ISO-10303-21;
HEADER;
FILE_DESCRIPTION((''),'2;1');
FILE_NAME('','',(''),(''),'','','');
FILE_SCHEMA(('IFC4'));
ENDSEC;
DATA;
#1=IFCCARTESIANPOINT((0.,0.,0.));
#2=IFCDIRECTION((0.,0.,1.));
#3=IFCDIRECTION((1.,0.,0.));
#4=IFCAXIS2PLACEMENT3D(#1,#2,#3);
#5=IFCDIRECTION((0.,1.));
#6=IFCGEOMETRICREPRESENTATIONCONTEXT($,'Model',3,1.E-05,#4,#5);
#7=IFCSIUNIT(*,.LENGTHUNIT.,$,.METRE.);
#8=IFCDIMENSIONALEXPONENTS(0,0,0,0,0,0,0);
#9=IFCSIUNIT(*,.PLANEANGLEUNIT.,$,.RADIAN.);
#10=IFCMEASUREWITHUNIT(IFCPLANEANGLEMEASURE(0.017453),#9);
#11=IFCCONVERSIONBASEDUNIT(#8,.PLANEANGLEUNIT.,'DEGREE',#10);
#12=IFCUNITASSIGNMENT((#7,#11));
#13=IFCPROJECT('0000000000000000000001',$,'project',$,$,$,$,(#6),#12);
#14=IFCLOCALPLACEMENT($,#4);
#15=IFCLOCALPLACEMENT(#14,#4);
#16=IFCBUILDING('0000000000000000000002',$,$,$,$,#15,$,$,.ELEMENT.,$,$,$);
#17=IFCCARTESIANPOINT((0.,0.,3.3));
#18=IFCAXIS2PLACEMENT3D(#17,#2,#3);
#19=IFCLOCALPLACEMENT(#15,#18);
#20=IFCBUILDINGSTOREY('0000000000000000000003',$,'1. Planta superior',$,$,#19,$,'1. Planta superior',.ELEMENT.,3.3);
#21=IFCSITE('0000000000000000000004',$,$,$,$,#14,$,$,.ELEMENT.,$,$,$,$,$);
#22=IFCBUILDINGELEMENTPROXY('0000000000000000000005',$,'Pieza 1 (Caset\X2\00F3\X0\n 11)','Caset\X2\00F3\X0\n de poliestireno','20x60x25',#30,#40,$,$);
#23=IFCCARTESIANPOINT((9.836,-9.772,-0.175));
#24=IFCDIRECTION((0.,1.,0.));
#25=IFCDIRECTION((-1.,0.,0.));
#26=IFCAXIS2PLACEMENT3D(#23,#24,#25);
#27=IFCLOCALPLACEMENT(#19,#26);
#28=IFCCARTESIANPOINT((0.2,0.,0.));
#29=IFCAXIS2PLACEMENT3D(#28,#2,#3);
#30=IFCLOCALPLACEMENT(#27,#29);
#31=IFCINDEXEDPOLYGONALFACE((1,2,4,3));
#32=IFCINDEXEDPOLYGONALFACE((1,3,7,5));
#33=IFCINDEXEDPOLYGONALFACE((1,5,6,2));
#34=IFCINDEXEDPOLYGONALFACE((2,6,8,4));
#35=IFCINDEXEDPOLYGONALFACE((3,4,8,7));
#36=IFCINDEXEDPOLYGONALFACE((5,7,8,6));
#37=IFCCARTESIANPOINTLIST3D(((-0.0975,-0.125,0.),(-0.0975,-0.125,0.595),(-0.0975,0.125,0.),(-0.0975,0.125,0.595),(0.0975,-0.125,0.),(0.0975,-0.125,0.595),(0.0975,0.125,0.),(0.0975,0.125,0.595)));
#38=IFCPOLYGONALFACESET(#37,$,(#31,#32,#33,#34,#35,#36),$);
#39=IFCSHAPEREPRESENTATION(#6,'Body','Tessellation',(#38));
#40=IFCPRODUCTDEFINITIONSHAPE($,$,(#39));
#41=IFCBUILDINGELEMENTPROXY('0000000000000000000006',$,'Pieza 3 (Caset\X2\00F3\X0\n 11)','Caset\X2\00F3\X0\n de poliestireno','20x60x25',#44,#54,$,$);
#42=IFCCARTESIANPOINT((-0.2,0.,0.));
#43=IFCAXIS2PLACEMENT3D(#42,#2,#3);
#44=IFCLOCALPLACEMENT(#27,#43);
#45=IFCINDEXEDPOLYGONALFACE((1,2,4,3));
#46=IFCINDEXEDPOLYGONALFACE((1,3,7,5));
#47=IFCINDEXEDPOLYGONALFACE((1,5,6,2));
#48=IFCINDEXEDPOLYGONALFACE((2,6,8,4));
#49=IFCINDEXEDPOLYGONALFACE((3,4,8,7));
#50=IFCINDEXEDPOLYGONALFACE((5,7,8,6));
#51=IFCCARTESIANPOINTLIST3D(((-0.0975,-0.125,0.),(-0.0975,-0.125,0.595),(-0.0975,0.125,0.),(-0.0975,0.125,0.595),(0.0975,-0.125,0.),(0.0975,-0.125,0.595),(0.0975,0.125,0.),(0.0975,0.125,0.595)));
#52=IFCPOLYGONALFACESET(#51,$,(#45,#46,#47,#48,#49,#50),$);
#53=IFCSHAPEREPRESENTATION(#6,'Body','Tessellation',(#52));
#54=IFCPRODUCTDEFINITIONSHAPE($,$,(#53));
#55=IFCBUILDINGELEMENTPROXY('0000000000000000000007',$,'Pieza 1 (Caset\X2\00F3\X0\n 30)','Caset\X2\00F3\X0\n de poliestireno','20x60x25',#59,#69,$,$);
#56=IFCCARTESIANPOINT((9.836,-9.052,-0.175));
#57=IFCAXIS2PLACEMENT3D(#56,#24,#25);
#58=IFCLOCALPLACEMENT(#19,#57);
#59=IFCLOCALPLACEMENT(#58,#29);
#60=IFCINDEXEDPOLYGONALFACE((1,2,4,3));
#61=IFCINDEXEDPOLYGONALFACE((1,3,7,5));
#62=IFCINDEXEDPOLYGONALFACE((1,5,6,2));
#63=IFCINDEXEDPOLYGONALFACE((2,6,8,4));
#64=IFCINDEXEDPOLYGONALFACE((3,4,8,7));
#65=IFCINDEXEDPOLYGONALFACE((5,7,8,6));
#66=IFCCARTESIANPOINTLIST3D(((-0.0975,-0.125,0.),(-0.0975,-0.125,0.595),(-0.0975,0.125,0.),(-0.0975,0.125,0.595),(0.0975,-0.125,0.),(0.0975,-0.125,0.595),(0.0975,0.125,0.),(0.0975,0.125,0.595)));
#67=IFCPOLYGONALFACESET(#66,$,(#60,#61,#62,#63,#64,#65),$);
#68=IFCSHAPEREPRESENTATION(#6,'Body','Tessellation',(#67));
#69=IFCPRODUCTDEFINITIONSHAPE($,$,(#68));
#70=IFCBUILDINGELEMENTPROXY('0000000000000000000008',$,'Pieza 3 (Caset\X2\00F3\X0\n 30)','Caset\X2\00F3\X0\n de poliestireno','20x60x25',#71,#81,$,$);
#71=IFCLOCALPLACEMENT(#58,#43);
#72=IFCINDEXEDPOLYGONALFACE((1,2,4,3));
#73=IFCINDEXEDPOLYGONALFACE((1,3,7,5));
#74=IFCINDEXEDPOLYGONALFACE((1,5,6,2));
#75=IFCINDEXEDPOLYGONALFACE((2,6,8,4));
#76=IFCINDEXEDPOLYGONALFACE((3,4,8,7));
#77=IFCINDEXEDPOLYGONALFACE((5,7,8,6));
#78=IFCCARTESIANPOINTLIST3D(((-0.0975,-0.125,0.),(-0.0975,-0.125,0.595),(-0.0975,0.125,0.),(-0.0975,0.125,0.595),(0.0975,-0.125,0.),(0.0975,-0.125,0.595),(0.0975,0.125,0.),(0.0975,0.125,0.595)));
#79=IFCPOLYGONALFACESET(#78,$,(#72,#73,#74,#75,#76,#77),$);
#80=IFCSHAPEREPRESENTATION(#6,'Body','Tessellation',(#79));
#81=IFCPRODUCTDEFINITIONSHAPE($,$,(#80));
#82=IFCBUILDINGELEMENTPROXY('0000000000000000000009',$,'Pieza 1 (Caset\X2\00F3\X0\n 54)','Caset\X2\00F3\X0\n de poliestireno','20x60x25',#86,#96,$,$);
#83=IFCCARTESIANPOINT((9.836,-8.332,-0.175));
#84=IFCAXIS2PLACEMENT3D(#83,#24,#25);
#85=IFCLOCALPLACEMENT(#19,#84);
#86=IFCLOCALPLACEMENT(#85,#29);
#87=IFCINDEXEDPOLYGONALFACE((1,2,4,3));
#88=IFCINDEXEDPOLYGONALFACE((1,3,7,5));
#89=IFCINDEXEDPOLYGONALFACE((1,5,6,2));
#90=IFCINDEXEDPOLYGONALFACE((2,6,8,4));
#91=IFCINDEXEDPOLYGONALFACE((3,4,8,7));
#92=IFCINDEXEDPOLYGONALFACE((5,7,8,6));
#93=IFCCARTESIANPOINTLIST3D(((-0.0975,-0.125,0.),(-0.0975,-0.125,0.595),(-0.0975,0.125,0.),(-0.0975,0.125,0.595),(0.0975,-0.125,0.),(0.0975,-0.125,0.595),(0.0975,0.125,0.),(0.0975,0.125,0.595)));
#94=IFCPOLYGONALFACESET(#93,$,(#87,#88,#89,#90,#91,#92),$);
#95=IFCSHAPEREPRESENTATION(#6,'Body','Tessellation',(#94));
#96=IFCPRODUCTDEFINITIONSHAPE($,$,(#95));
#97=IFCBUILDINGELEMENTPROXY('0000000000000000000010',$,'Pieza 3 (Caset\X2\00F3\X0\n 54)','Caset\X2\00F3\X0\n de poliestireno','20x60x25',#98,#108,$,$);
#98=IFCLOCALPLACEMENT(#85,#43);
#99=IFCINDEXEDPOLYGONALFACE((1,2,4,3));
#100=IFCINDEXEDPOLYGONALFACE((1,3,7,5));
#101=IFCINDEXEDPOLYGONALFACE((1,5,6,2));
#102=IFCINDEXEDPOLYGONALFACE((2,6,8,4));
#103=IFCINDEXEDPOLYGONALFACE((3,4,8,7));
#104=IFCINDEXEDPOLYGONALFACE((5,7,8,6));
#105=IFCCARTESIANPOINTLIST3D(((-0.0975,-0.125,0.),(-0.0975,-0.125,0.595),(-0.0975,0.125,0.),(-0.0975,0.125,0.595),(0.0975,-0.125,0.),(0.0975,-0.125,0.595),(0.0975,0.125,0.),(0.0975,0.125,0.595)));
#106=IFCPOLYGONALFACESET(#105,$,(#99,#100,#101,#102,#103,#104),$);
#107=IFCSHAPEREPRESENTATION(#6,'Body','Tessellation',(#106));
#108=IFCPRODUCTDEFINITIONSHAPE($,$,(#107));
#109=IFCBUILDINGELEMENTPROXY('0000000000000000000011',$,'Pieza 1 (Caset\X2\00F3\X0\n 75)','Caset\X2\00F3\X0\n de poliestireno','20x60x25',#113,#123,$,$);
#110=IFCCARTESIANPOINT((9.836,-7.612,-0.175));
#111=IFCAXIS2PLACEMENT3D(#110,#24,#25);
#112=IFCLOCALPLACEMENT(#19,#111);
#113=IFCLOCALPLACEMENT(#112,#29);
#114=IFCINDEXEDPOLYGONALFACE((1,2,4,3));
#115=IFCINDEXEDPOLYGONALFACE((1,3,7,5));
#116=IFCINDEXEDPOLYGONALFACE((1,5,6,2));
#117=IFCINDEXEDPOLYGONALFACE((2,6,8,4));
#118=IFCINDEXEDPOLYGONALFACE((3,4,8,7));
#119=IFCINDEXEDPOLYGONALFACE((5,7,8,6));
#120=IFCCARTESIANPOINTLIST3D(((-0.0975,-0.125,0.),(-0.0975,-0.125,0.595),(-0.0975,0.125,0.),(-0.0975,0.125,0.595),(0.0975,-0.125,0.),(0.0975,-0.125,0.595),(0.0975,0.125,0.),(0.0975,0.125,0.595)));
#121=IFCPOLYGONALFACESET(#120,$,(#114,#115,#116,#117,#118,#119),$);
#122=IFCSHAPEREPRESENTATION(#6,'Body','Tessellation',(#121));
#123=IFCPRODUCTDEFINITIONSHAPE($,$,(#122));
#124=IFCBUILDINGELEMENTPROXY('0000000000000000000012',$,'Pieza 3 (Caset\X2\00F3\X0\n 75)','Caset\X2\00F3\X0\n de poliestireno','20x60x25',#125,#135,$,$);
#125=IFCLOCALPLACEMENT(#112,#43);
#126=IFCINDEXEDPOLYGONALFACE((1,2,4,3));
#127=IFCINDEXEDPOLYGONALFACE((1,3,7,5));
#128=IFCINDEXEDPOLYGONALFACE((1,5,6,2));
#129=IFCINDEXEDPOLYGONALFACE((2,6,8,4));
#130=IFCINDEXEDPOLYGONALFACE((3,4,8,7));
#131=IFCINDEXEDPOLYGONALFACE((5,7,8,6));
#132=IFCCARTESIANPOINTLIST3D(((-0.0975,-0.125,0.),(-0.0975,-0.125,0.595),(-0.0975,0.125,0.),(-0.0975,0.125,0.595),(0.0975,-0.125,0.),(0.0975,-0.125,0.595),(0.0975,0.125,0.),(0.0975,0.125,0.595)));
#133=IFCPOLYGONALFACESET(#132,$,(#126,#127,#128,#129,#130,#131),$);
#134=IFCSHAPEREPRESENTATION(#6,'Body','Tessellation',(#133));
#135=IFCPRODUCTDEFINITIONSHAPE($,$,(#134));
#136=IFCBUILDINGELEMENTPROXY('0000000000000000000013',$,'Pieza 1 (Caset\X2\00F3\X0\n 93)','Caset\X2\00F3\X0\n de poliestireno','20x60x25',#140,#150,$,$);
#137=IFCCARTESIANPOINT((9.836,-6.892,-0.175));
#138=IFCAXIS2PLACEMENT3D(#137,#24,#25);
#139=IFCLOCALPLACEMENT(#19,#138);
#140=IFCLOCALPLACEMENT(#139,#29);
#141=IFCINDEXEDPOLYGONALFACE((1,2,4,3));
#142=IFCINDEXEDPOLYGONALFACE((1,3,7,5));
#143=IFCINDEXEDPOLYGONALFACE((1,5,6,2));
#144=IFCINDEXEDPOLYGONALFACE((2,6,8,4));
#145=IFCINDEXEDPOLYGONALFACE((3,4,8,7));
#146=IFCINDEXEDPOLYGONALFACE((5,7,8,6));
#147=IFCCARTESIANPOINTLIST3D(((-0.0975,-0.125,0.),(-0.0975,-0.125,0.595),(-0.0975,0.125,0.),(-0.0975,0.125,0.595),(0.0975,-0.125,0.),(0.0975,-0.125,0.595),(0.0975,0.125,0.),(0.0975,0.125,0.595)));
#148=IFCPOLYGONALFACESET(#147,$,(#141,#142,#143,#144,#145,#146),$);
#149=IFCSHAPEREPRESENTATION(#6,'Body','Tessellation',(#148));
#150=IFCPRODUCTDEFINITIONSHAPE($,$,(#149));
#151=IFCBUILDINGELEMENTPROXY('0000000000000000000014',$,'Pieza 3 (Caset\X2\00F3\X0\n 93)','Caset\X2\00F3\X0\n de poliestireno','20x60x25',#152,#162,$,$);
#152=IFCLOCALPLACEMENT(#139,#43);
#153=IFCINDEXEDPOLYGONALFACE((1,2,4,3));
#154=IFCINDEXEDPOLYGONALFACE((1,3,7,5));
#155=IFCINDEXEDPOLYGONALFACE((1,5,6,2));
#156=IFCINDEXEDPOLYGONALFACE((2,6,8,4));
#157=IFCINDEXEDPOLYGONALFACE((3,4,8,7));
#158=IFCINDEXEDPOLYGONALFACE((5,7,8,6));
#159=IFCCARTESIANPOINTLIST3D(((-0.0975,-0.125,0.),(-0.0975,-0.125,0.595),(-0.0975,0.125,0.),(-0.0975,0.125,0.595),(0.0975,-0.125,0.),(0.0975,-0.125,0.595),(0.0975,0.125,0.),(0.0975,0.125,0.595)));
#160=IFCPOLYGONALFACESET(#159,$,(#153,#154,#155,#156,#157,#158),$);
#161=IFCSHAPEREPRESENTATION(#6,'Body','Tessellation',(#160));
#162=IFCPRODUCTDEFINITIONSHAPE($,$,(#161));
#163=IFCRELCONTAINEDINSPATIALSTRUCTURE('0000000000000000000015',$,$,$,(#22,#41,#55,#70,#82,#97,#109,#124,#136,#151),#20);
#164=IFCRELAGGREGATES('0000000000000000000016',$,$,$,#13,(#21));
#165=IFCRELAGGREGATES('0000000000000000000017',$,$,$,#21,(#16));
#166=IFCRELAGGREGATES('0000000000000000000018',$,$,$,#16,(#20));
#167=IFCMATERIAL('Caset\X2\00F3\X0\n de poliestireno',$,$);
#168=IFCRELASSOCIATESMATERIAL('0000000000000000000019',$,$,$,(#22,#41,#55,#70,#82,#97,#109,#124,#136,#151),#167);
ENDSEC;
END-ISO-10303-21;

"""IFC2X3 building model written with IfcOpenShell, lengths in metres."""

from ifc_helpers import new_model, entity, si_unit, converted_unit, direction, frame, origin_with_axes, origin_2d_with_axis, place, context, project, spatial, rectangle, extrude, source, transform, mapped, material, element, save


model = new_model("IFC2X3")

# Units and contexts
model_context = context("Model", 3, precision=1e-05, world=origin_with_axes(), true_north=direction((0.0, 1.0)))
ifc_project = project(units=[si_unit("LENGTHUNIT", "METRE"), converted_unit("PLANEANGLEUNIT", "DEGREE", entity("IfcPlaneAngleMeasure", 0.017453), si_unit("PLANEANGLEUNIT", "RADIAN"), dimensions=[0, 0, 0, 0, 0, 0, 0])], contexts=[model_context])

# Site, building, storey
site_placement = place(None, origin_with_axes())
site = spatial("IfcSite", under=ifc_project, at=site_placement, CompositionType="ELEMENT")
building_placement = place(site_placement, origin_with_axes())
building = spatial("IfcBuilding", under=site, at=building_placement, CompositionType="ELEMENT")
storey_placement = place(building_placement, frame((0.0, 0.0, 3.3), z_axis=(0.0, 0.0, 1.0), x_axis=(1.0, 0.0, 0.0)))
storey = spatial("IfcBuildingStorey", under=building, at=storey_placement, Name="1. Planta superior", LongName="1. Planta superior", CompositionType="ELEMENT", Elevation=3.3)

# Building element proxies
ifc_material = material(Name="Casetón de poliestireno")
shared_shape = source(origin_with_axes(), model_context, "Body", "SweptSolid", [
    extrude(rectangle(XDim=0.195, YDim=0.25, at=origin_2d_with_axis()), origin_with_axes(), (0.0, 0.0, 1.0), 0.595),
])
placement_1 = place(storey_placement, frame((9.836, -9.772, -0.175), z_axis=(0.0, 1.0, 0.0), x_axis=(-1.0, 0.0, 0.0)))
for number, where, z_axis, x_axis, name in (
    (1, (0.2, 0.0, 0.0), (0.0, 0.0, 1.0), (1.0, 0.0, 0.0), "Pieza 1 (Casetón 11)"),
    (2, (-0.2, 0.0, 0.0), (0.0, 0.0, 1.0), (1.0, 0.0, 0.0), "Pieza 3 (Casetón 11)"),
):
    element("IfcBuildingElementProxy", number, at=place(placement_1, frame(where, z_axis=z_axis, x_axis=x_axis)), inside=storey, material=ifc_material, Name=name, Description="Casetón de poliestireno", ObjectType="20x60x25", context=model_context, shape_type="MappedRepresentation", body=[
        mapped(shared_shape, transform((0.0, 0.0, 0.0), x_axis=(1.0, 0.0, 0.0), y_axis=(0.0, 1.0, 0.0), z_axis=(0.0, 0.0, 1.0))),
    ])
placement_2 = place(storey_placement, frame((9.836, -9.052, -0.175), z_axis=(0.0, 1.0, 0.0), x_axis=(-1.0, 0.0, 0.0)))
for number, where, z_axis, x_axis, name in (
    (3, (0.2, 0.0, 0.0), (0.0, 0.0, 1.0), (1.0, 0.0, 0.0), "Pieza 1 (Casetón 30)"),
    (4, (-0.2, 0.0, 0.0), (0.0, 0.0, 1.0), (1.0, 0.0, 0.0), "Pieza 3 (Casetón 30)"),
):
    element("IfcBuildingElementProxy", number, at=place(placement_2, frame(where, z_axis=z_axis, x_axis=x_axis)), inside=storey, material=ifc_material, Name=name, Description="Casetón de poliestireno", ObjectType="20x60x25", context=model_context, shape_type="MappedRepresentation", body=[
        mapped(shared_shape, transform((0.0, 0.0, 0.0), x_axis=(1.0, 0.0, 0.0), y_axis=(0.0, 1.0, 0.0), z_axis=(0.0, 0.0, 1.0))),
    ])
placement_3 = place(storey_placement, frame((9.836, -8.332, -0.175), z_axis=(0.0, 1.0, 0.0), x_axis=(-1.0, 0.0, 0.0)))
for number, where, z_axis, x_axis, name in (
    (5, (0.2, 0.0, 0.0), (0.0, 0.0, 1.0), (1.0, 0.0, 0.0), "Pieza 1 (Casetón 54)"),
    (6, (-0.2, 0.0, 0.0), (0.0, 0.0, 1.0), (1.0, 0.0, 0.0), "Pieza 3 (Casetón 54)"),
):
    element("IfcBuildingElementProxy", number, at=place(placement_3, frame(where, z_axis=z_axis, x_axis=x_axis)), inside=storey, material=ifc_material, Name=name, Description="Casetón de poliestireno", ObjectType="20x60x25", context=model_context, shape_type="MappedRepresentation", body=[
        mapped(shared_shape, transform((0.0, 0.0, 0.0), x_axis=(1.0, 0.0, 0.0), y_axis=(0.0, 1.0, 0.0), z_axis=(0.0, 0.0, 1.0))),
    ])
placement_4 = place(storey_placement, frame((9.836, -7.612, -0.175), z_axis=(0.0, 1.0, 0.0), x_axis=(-1.0, 0.0, 0.0)))
for number, where, z_axis, x_axis, name in (
    (7, (0.2, 0.0, 0.0), (0.0, 0.0, 1.0), (1.0, 0.0, 0.0), "Pieza 1 (Casetón 75)"),
    (8, (-0.2, 0.0, 0.0), (0.0, 0.0, 1.0), (1.0, 0.0, 0.0), "Pieza 3 (Casetón 75)"),
):
    element("IfcBuildingElementProxy", number, at=place(placement_4, frame(where, z_axis=z_axis, x_axis=x_axis)), inside=storey, material=ifc_material, Name=name, Description="Casetón de poliestireno", ObjectType="20x60x25", context=model_context, shape_type="MappedRepresentation", body=[
        mapped(shared_shape, transform((0.0, 0.0, 0.0), x_axis=(1.0, 0.0, 0.0), y_axis=(0.0, 1.0, 0.0), z_axis=(0.0, 0.0, 1.0))),
    ])
placement_5 = place(storey_placement, frame((9.836, -6.892, -0.175), z_axis=(0.0, 1.0, 0.0), x_axis=(-1.0, 0.0, 0.0)))
for number, where, z_axis, x_axis, name in (
    (9, (0.2, 0.0, 0.0), (0.0, 0.0, 1.0), (1.0, 0.0, 0.0), "Pieza 1 (Casetón 93)"),
    (10, (-0.2, 0.0, 0.0), (0.0, 0.0, 1.0), (1.0, 0.0, 0.0), "Pieza 3 (Casetón 93)"),
):
    element("IfcBuildingElementProxy", number, at=place(placement_5, frame(where, z_axis=z_axis, x_axis=x_axis)), inside=storey, material=ifc_material, Name=name, Description="Casetón de poliestireno", ObjectType="20x60x25", context=model_context, shape_type="MappedRepresentation", body=[
        mapped(shared_shape, transform((0.0, 0.0, 0.0), x_axis=(1.0, 0.0, 0.0), y_axis=(0.0, 1.0, 0.0), z_axis=(0.0, 0.0, 1.0))),
    ])

save(model, "model.ifc")
